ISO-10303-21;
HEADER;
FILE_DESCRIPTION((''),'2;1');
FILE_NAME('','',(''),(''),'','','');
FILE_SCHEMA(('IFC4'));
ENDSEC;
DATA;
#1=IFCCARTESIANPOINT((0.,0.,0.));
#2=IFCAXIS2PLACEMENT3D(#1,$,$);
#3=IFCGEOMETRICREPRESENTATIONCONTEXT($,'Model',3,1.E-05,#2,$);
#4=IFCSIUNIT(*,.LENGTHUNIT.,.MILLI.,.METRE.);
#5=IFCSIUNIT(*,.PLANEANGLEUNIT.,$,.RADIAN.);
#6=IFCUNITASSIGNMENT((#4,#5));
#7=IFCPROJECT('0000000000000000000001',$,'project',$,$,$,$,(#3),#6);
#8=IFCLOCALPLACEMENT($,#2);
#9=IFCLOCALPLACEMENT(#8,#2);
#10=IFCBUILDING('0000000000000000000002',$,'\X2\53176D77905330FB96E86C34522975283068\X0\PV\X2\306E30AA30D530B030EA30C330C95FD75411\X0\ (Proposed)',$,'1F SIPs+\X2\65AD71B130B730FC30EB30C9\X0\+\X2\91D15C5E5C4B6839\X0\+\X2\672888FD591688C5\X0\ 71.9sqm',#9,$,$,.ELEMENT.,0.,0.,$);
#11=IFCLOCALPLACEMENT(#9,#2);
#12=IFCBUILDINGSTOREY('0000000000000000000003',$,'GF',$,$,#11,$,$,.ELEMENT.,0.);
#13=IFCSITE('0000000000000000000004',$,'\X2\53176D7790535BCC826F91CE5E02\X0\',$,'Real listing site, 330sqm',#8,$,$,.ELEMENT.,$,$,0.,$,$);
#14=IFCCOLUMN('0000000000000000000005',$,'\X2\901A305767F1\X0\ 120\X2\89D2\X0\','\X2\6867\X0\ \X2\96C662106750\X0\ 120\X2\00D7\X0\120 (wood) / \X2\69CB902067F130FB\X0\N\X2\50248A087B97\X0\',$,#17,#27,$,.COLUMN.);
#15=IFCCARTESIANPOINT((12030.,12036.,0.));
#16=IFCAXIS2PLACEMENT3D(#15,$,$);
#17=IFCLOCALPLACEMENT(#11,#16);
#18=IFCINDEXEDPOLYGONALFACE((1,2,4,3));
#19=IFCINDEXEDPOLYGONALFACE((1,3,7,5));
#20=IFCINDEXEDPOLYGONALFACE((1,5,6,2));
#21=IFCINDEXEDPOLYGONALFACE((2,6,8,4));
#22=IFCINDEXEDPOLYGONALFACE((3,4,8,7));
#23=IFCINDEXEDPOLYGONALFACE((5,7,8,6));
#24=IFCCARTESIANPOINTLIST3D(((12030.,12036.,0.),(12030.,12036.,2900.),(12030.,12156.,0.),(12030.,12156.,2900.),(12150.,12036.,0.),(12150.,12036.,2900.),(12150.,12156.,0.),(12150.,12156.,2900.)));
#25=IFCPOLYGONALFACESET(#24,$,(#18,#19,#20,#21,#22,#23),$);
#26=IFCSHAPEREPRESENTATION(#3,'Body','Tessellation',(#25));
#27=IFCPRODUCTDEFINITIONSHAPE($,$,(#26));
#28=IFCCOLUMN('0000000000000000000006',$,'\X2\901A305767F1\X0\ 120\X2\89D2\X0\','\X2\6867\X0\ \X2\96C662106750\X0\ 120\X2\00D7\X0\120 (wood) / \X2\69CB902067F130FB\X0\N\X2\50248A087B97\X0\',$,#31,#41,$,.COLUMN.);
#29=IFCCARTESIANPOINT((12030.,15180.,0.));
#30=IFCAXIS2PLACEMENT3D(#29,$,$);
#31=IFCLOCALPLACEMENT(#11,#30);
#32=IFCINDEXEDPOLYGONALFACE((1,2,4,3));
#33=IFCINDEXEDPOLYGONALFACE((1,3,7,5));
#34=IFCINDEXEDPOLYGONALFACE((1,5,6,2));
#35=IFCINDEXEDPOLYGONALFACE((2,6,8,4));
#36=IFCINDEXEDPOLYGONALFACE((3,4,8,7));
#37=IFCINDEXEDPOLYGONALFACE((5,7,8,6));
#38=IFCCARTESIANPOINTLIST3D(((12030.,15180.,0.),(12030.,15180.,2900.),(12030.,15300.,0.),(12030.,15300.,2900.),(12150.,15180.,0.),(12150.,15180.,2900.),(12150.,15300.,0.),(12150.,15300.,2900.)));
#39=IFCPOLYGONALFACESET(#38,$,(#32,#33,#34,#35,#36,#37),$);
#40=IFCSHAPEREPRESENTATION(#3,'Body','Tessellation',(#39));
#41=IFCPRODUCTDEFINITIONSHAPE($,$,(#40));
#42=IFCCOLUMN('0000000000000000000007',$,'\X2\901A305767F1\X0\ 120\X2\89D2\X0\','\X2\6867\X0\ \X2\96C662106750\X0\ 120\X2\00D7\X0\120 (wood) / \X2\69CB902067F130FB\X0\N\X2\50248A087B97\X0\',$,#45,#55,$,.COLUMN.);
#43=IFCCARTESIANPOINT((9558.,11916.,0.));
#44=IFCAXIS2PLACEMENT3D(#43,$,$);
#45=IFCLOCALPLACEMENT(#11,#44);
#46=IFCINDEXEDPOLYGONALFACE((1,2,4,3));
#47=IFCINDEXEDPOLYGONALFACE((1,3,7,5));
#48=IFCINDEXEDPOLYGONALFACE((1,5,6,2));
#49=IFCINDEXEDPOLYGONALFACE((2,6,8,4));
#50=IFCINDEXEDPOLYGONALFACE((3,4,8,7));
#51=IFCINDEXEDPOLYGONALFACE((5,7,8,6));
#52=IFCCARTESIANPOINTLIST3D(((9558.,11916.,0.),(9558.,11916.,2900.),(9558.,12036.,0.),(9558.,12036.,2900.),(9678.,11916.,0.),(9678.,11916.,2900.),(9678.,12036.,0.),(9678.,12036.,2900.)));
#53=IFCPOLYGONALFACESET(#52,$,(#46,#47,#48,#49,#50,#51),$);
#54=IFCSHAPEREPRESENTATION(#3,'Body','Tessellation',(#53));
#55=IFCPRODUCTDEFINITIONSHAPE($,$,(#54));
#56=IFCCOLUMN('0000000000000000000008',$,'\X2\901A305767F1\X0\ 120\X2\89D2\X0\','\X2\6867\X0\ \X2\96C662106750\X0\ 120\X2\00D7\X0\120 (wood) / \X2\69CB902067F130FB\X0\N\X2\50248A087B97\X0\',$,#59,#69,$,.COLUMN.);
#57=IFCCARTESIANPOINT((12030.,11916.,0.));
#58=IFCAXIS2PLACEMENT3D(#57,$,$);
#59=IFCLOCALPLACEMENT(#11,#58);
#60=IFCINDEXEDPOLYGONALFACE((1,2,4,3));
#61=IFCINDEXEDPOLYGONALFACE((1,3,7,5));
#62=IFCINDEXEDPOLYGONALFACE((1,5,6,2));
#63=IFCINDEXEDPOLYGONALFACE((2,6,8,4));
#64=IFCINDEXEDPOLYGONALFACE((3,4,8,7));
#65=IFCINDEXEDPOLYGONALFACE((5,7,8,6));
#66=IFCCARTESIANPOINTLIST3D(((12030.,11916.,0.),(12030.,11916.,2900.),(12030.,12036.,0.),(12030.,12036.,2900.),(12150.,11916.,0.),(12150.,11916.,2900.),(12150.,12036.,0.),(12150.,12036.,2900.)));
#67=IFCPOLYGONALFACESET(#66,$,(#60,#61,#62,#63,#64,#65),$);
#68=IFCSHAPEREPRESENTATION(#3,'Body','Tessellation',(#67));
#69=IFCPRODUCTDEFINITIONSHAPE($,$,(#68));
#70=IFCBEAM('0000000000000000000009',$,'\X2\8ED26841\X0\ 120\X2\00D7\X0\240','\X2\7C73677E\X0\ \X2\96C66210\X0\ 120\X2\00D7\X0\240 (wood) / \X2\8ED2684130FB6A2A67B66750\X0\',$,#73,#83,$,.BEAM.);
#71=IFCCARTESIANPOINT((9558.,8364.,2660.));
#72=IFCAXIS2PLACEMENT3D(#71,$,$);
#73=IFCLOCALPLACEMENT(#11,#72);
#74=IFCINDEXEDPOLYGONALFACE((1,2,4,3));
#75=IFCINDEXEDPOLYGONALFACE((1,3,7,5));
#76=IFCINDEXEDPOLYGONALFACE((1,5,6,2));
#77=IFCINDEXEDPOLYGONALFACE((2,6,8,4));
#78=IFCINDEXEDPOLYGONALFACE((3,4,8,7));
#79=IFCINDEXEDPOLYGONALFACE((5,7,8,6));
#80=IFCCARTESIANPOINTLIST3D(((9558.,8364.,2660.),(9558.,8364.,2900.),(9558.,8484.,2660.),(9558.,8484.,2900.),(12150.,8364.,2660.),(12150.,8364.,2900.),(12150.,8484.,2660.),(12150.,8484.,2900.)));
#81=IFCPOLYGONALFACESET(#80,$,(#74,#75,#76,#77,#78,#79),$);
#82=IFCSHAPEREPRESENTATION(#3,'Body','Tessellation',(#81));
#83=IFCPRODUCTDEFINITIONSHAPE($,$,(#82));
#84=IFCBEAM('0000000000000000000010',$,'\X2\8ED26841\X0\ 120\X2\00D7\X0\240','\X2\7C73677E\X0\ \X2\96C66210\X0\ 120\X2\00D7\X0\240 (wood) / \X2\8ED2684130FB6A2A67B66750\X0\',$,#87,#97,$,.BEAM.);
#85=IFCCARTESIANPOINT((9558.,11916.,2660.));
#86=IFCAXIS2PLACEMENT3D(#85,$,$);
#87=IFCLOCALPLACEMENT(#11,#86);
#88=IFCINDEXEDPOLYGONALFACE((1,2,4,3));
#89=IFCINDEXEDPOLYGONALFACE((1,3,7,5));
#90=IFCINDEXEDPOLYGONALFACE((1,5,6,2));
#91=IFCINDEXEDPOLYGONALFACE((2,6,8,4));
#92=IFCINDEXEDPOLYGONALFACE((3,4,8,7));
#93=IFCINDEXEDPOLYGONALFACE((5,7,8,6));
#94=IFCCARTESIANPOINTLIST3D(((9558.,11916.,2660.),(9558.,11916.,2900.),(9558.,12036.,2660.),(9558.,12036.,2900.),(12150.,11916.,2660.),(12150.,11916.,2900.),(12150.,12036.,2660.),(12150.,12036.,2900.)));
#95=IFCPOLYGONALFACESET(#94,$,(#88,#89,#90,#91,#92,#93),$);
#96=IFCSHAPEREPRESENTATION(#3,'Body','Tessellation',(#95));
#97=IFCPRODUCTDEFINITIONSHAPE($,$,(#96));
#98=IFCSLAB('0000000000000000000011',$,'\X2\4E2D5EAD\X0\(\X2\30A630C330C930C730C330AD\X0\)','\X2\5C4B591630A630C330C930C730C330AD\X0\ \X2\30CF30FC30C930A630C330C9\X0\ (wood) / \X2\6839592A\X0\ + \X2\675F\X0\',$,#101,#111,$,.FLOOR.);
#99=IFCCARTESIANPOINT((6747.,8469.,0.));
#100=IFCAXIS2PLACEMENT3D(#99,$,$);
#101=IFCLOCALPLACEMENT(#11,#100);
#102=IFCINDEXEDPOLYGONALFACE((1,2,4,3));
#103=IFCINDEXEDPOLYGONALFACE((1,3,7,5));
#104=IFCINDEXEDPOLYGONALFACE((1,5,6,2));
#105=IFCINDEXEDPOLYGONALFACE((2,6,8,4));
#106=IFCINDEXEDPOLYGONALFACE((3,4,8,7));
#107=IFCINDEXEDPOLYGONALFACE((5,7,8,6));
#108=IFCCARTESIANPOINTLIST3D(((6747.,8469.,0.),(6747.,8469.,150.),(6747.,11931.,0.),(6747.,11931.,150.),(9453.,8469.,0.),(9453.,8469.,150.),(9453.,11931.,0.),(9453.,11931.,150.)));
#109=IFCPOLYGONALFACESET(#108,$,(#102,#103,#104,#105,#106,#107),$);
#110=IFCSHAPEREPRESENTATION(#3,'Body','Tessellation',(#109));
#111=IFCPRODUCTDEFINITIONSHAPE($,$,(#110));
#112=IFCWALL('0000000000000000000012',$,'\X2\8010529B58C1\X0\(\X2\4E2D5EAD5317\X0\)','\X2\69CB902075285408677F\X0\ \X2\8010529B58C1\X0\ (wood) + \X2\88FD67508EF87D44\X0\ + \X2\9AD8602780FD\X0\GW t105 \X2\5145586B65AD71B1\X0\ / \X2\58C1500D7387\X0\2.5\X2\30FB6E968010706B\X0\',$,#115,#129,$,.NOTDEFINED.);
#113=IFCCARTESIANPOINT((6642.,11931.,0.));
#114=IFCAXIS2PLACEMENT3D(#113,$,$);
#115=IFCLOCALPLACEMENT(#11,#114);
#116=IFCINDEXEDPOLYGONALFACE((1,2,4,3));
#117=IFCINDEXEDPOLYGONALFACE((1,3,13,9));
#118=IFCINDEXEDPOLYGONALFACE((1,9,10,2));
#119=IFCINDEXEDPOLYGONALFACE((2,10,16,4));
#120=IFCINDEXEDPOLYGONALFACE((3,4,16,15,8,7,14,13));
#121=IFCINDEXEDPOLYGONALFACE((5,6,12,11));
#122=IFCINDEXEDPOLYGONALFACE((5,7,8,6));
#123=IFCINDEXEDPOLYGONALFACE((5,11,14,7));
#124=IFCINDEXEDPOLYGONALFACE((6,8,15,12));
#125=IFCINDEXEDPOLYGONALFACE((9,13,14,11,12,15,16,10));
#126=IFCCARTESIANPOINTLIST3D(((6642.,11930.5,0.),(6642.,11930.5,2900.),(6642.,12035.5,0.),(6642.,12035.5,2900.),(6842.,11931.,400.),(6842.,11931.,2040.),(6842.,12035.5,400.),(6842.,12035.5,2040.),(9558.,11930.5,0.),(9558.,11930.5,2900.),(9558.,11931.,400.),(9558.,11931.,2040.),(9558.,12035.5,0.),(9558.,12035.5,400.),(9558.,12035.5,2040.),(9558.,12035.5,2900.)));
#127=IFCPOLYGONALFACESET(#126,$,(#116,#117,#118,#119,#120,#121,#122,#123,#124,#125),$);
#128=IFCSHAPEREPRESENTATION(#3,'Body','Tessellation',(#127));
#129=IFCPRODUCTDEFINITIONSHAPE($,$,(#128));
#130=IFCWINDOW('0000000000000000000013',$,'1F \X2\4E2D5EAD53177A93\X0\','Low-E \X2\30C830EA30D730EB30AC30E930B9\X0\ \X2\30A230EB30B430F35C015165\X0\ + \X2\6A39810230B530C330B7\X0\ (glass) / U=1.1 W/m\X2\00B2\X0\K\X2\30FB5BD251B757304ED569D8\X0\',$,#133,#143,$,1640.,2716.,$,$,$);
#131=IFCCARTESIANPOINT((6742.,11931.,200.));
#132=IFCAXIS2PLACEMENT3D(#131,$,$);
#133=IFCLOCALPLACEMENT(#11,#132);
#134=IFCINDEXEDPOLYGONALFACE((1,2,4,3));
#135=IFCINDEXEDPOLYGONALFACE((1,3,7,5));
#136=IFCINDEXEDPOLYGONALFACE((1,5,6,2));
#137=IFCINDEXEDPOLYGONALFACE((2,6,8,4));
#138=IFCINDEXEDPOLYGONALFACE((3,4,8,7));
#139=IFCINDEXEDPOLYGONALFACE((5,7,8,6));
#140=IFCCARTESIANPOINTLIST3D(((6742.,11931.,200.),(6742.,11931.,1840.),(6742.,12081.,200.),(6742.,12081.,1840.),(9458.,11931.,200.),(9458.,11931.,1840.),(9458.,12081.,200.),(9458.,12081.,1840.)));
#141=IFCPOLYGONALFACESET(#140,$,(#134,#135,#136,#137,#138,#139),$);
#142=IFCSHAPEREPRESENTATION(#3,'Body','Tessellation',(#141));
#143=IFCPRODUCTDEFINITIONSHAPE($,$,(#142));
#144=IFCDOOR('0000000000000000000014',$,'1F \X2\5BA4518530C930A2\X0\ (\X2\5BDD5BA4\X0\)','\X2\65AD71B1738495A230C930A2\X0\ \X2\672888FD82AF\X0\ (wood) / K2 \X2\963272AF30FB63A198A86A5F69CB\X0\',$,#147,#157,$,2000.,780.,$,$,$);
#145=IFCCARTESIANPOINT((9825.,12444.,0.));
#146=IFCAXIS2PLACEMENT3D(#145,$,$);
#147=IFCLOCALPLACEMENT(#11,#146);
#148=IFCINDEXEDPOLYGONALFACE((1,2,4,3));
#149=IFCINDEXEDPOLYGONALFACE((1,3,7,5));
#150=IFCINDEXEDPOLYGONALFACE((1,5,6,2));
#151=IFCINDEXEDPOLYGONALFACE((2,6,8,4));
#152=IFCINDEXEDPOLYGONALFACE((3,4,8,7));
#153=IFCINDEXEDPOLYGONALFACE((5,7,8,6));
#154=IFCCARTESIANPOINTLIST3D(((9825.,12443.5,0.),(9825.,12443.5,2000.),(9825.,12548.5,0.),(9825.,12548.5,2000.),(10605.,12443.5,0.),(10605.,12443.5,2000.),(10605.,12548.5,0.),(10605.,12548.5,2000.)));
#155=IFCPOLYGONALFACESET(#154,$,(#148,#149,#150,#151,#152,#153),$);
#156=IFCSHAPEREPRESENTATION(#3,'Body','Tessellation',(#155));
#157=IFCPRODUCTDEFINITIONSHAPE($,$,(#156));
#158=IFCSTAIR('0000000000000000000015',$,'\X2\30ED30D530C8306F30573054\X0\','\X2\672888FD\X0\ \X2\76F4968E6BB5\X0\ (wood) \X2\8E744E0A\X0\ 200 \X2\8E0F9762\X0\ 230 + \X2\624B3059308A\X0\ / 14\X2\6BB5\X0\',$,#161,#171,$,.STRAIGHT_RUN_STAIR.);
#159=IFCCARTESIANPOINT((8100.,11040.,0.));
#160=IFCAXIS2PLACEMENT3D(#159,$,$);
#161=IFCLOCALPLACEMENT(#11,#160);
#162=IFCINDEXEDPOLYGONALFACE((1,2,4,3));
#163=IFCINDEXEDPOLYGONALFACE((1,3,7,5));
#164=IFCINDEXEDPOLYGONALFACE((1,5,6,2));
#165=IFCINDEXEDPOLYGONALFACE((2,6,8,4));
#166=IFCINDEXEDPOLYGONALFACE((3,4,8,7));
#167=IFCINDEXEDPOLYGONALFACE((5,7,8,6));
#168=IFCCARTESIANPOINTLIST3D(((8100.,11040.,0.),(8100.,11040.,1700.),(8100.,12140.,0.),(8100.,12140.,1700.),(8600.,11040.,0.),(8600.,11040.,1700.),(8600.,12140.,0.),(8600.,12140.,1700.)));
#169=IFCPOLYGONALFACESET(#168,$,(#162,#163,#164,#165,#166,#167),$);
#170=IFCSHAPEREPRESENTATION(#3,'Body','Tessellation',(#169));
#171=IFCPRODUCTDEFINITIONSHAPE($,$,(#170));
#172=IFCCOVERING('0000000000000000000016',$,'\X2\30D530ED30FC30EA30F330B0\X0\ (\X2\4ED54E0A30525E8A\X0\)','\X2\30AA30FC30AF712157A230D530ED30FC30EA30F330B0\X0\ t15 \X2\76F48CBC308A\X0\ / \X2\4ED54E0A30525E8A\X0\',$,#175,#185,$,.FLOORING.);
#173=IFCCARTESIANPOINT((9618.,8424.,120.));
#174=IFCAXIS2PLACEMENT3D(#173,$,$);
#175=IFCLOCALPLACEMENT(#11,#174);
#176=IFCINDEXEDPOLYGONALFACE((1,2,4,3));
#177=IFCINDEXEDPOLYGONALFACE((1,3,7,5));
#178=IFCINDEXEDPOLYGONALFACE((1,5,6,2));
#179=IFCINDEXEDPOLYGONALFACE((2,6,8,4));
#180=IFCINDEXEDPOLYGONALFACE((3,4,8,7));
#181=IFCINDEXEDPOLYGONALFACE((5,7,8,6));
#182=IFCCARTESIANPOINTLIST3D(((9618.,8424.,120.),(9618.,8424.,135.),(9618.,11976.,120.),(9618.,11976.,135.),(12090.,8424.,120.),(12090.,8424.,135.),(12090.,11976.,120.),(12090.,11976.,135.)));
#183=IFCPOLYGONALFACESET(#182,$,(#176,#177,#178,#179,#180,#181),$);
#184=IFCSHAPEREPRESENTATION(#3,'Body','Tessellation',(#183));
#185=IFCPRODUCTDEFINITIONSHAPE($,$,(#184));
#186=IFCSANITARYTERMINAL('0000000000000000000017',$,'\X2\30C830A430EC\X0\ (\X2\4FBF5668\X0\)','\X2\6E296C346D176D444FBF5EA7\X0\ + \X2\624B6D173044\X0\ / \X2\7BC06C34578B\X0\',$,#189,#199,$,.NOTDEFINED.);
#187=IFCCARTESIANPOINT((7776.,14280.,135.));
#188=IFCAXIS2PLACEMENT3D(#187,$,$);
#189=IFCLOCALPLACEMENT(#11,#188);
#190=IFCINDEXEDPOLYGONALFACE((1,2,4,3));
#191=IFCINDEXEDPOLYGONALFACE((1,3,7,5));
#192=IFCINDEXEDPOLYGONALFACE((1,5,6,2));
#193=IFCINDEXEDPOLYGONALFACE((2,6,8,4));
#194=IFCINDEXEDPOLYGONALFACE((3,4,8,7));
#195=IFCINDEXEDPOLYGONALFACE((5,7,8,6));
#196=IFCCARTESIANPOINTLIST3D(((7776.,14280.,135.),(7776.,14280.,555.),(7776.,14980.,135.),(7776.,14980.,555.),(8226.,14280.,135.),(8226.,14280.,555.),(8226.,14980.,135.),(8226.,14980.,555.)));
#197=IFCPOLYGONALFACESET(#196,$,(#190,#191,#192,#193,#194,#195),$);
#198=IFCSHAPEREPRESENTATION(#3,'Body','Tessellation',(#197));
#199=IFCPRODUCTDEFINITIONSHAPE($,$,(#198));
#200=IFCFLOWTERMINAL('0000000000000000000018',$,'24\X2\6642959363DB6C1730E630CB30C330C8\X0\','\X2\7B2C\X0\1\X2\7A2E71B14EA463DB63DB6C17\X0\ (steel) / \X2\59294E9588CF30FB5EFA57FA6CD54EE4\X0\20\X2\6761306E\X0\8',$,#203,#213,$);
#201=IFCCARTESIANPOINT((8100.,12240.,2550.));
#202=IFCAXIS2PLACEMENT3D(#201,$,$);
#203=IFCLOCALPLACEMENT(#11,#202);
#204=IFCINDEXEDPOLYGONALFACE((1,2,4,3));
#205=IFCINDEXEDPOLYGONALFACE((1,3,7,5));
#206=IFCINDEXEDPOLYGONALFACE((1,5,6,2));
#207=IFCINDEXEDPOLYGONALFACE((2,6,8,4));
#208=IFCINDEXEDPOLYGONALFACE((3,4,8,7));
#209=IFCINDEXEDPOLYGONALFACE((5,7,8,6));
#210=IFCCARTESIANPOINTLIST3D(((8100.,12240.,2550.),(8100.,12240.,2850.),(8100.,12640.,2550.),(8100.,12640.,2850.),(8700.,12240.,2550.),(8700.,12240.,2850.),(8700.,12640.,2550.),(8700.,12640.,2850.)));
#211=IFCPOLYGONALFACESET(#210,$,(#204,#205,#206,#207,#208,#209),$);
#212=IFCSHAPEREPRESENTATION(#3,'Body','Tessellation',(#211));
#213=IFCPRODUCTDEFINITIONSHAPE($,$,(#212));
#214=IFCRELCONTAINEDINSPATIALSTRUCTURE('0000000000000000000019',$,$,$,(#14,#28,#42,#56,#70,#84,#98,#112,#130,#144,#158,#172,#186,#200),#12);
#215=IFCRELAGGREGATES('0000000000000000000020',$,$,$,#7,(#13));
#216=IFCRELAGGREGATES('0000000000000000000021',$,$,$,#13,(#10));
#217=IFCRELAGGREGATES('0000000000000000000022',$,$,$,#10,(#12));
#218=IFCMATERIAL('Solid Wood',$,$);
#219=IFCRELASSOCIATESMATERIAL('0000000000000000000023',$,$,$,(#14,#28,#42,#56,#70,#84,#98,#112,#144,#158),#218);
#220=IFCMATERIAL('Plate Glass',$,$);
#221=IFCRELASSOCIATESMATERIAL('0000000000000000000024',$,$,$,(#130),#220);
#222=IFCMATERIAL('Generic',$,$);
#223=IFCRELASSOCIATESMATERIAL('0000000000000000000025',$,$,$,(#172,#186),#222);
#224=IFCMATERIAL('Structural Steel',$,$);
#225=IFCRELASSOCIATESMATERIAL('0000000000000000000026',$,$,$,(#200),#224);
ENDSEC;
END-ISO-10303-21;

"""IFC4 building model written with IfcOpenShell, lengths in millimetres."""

from ifc_helpers import new_model, si_unit, frame, frame_2d, origin, place, context, project, spatial, rectangle, extrude, material, element, fill, save


model = new_model("IFC4")

# Units and contexts
model_context = context("Model", 3, precision=1e-05, world=origin())
ifc_project = project(units=[si_unit("LENGTHUNIT", "METRE", prefix="MILLI"), si_unit("PLANEANGLEUNIT", "RADIAN")], contexts=[model_context])

# Site, building, storey
site_placement = place(None, origin())
site = spatial("IfcSite", under=ifc_project, at=site_placement, Name="北海道富良野市", ObjectType="Real listing site, 330sqm", CompositionType="ELEMENT", RefElevation=0.0)
building_placement = place(site_placement, origin())
building = spatial("IfcBuilding", under=site, at=building_placement, Name="北海道・雨水利用とPVのオフグリッド志向 (Proposed)", ObjectType="1F SIPs+断熱シールド+金属屋根+木製外装 71.9sqm", CompositionType="ELEMENT", ElevationOfRefHeight=0.0, ElevationOfTerrain=0.0)
storey_placement = place(building_placement, origin())
storey = spatial("IfcBuildingStorey", under=building, at=storey_placement, Name="GF", CompositionType="ELEMENT", Elevation=0.0)

# Columns
ifc_material_1 = material(Name="Solid Wood")
column_1_placement = place(storey_placement, frame((12030.0, 12036.0, 0.0)))
element("IfcColumn", 1, at=column_1_placement, inside=storey, material=ifc_material_1, Name="通し柱 120角", Description="桧 集成材 120×120 (wood) / 構造柱・N値計算", PredefinedType="COLUMN", context=model_context, shape_type="SweptSolid", body=[
    extrude(rectangle(XDim=120.0, YDim=120.0, at=frame_2d((60.0, 60.0))), frame((12030.0, 12036.0, 0.0)), (0.0, 0.0, 1.0), 2900.0),
])
column_2_placement = place(storey_placement, frame((12030.0, 15180.0, 0.0)))
element("IfcColumn", 2, at=column_2_placement, inside=storey, material=ifc_material_1, Name="通し柱 120角", Description="桧 集成材 120×120 (wood) / 構造柱・N値計算", PredefinedType="COLUMN", context=model_context, shape_type="SweptSolid", body=[
    extrude(rectangle(XDim=120.0, YDim=120.0, at=frame_2d((60.0, 60.0))), frame((12030.0, 15180.0, 0.0)), (0.0, 0.0, 1.0), 2900.0),
])
column_3_placement = place(storey_placement, frame((9558.0, 11916.0, 0.0)))
element("IfcColumn", 3, at=column_3_placement, inside=storey, material=ifc_material_1, Name="通し柱 120角", Description="桧 集成材 120×120 (wood) / 構造柱・N値計算", PredefinedType="COLUMN", context=model_context, shape_type="SweptSolid", body=[
    extrude(rectangle(XDim=120.0, YDim=120.0, at=frame_2d((60.0, 60.0))), frame((9558.0, 11916.0, 0.0)), (0.0, 0.0, 1.0), 2900.0),
])
column_4_placement = place(storey_placement, frame((12030.0, 11916.0, 0.0)))
element("IfcColumn", 4, at=column_4_placement, inside=storey, material=ifc_material_1, Name="通し柱 120角", Description="桧 集成材 120×120 (wood) / 構造柱・N値計算", PredefinedType="COLUMN", context=model_context, shape_type="SweptSolid", body=[
    extrude(rectangle(XDim=120.0, YDim=120.0, at=frame_2d((60.0, 60.0))), frame((12030.0, 11916.0, 0.0)), (0.0, 0.0, 1.0), 2900.0),
])

# Beams
beam_1_placement = place(storey_placement, frame((9558.0, 8364.0, 2660.0)))
element("IfcBeam", 5, at=beam_1_placement, inside=storey, material=ifc_material_1, Name="軒桁 120×240", Description="米松 集成 120×240 (wood) / 軒桁・横架材", PredefinedType="BEAM", context=model_context, shape_type="SweptSolid", body=[
    extrude(rectangle(XDim=2592.0, YDim=120.0, at=frame_2d((1296.0, 60.0))), frame((9558.0, 8364.0, 2660.0)), (0.0, 0.0, 1.0), 240.0),
])
beam_2_placement = place(storey_placement, frame((9558.0, 11916.0, 2660.0)))
element("IfcBeam", 6, at=beam_2_placement, inside=storey, material=ifc_material_1, Name="軒桁 120×240", Description="米松 集成 120×240 (wood) / 軒桁・横架材", PredefinedType="BEAM", context=model_context, shape_type="SweptSolid", body=[
    extrude(rectangle(XDim=2592.0, YDim=120.0, at=frame_2d((1296.0, 60.0))), frame((9558.0, 11916.0, 2660.0)), (0.0, 0.0, 1.0), 240.0),
])

# Slab
slab_placement = place(storey_placement, frame((6747.0, 8469.0, 0.0)))
element("IfcSlab", 7, at=slab_placement, inside=storey, material=ifc_material_1, Name="中庭(ウッドデッキ)", Description="屋外ウッドデッキ ハードウッド (wood) / 根太 + 束", PredefinedType="FLOOR", context=model_context, shape_type="SweptSolid", body=[
    extrude(rectangle(XDim=2706.0, YDim=3462.0, at=frame_2d((1353.0, 1731.0))), frame((6747.0, 8469.0, 0.0)), (0.0, 0.0, 1.0), 150.0),
])

# Wall, opening, window
wall_1_placement = place(storey_placement, frame((6642.0, 11931.0, 0.0)))
wall_1 = element("IfcWall", 8, at=wall_1_placement, inside=storey, material=ifc_material_1, Name="耐力壁(中庭北)", Description="構造用合板 耐力壁 (wood) + 製材軸組 + 高性能GW t105 充填断熱 / 壁倍率2.5・準耐火", PredefinedType="NOTDEFINED", context=model_context, shape_type="SweptSolid", body=[
    extrude(rectangle(XDim=2916.0, YDim=105.0, at=frame_2d((1458.0, 52.0))), frame((6642.0, 11931.0, 0.0)), (0.0, 0.0, 1.0), 2900.0),
])
opening_placement = place(storey_placement, frame((6742.0, 11931.0, 200.0)))
opening = element("IfcOpeningElement", 9, at=opening_placement, cuts=wall_1, PredefinedType="NOTDEFINED", context=model_context, shape_type="SweptSolid", body=[
    extrude(rectangle(XDim=2716.0, YDim=150.0, at=frame_2d((1358.0, 75.0))), frame((6742.0, 11931.0, 200.0)), (0.0, 0.0, 1.0), 1640.0),
])
ifc_material_2 = material(Name="Plate Glass")
window_placement = place(storey_placement, frame((6742.0, 11931.0, 200.0)))
window = element("IfcWindow", 10, at=window_placement, inside=storey, material=ifc_material_2, Name="1F 中庭北窓", Description="Low-E トリプルガラス アルゴン封入 + 樹脂サッシ (glass) / U=1.1 W/m²K・寒冷地仕様", OverallHeight=1640.0, OverallWidth=2716.0, context=model_context, shape_type="SweptSolid", body=[
    extrude(rectangle(XDim=2716.0, YDim=150.0, at=frame_2d((1358.0, 75.0))), frame((6742.0, 11931.0, 200.0)), (0.0, 0.0, 1.0), 1640.0),
])
fill(opening, window)

# Door
door_placement = place(storey_placement, frame((9825.0, 12444.0, 0.0)))
element("IfcDoor", 11, at=door_placement, inside=storey, material=ifc_material_1, Name="1F 室内ドア (寝室)", Description="断熱玄関ドア 木製芯 (wood) / K2 防犯・採風機構", OverallHeight=2000.0, OverallWidth=780.0, context=model_context, shape_type="SweptSolid", body=[
    extrude(rectangle(XDim=780.0, YDim=105.0, at=frame_2d((390.0, 52.0))), frame((9825.0, 12444.0, 0.0)), (0.0, 0.0, 1.0), 2000.0),
])

# Stair
stair_placement = place(storey_placement, frame((8100.0, 11040.0, 0.0)))
element("IfcStair", 12, at=stair_placement, inside=storey, material=ifc_material_1, Name="ロフトはしご", Description="木製 直階段 (wood) 蹴上 200 踏面 230 + 手すり / 14段", PredefinedType="STRAIGHT_RUN_STAIR", context=model_context, shape_type="SweptSolid", body=[
    extrude(rectangle(XDim=500.0, YDim=1100.0, at=frame_2d((250.0, 550.0))), frame((8100.0, 11040.0, 0.0)), (0.0, 0.0, 1.0), 1700.0),
])

# Covering
ifc_material_3 = material(Name="Generic")
covering_placement = place(storey_placement, frame((9618.0, 8424.0, 120.0)))
element("IfcCovering", 13, at=covering_placement, inside=storey, material=ifc_material_3, Name="フローリング (仕上げ床)", Description="オーク無垢フローリング t15 直貼り / 仕上げ床", PredefinedType="FLOORING", context=model_context, shape_type="SweptSolid", body=[
    extrude(rectangle(XDim=2472.0, YDim=3552.0, at=frame_2d((1236.0, 1776.0))), frame((9618.0, 8424.0, 120.0)), (0.0, 0.0, 1.0), 15.0),
])

# Sanitary terminal
sanitary_terminal_placement = place(storey_placement, frame((7776.0, 14280.0, 135.0)))
element("IfcSanitaryTerminal", 14, at=sanitary_terminal_placement, inside=storey, material=ifc_material_3, Name="トイレ (便器)", Description="温水洗浄便座 + 手洗い / 節水型", PredefinedType="NOTDEFINED", context=model_context, shape_type="SweptSolid", body=[
    extrude(rectangle(XDim=450.0, YDim=700.0, at=frame_2d((225.0, 350.0))), frame((7776.0, 14280.0, 135.0)), (0.0, 0.0, 1.0), 420.0),
])

# Flow terminal
ifc_material_4 = material(Name="Structural Steel")
flow_terminal_placement = place(storey_placement, frame((8100.0, 12240.0, 2550.0)))
element("IfcFlowTerminal", 15, at=flow_terminal_placement, inside=storey, material=ifc_material_4, Name="24時間換気ユニット", Description="第1種熱交換換気 (steel) / 天井裏・建基法令20条の8", context=model_context, shape_type="SweptSolid", body=[
    extrude(rectangle(XDim=600.0, YDim=400.0, at=frame_2d((300.0, 200.0))), frame((8100.0, 12240.0, 2550.0)), (0.0, 0.0, 1.0), 300.0),
])

save(model, "model.ifc")
